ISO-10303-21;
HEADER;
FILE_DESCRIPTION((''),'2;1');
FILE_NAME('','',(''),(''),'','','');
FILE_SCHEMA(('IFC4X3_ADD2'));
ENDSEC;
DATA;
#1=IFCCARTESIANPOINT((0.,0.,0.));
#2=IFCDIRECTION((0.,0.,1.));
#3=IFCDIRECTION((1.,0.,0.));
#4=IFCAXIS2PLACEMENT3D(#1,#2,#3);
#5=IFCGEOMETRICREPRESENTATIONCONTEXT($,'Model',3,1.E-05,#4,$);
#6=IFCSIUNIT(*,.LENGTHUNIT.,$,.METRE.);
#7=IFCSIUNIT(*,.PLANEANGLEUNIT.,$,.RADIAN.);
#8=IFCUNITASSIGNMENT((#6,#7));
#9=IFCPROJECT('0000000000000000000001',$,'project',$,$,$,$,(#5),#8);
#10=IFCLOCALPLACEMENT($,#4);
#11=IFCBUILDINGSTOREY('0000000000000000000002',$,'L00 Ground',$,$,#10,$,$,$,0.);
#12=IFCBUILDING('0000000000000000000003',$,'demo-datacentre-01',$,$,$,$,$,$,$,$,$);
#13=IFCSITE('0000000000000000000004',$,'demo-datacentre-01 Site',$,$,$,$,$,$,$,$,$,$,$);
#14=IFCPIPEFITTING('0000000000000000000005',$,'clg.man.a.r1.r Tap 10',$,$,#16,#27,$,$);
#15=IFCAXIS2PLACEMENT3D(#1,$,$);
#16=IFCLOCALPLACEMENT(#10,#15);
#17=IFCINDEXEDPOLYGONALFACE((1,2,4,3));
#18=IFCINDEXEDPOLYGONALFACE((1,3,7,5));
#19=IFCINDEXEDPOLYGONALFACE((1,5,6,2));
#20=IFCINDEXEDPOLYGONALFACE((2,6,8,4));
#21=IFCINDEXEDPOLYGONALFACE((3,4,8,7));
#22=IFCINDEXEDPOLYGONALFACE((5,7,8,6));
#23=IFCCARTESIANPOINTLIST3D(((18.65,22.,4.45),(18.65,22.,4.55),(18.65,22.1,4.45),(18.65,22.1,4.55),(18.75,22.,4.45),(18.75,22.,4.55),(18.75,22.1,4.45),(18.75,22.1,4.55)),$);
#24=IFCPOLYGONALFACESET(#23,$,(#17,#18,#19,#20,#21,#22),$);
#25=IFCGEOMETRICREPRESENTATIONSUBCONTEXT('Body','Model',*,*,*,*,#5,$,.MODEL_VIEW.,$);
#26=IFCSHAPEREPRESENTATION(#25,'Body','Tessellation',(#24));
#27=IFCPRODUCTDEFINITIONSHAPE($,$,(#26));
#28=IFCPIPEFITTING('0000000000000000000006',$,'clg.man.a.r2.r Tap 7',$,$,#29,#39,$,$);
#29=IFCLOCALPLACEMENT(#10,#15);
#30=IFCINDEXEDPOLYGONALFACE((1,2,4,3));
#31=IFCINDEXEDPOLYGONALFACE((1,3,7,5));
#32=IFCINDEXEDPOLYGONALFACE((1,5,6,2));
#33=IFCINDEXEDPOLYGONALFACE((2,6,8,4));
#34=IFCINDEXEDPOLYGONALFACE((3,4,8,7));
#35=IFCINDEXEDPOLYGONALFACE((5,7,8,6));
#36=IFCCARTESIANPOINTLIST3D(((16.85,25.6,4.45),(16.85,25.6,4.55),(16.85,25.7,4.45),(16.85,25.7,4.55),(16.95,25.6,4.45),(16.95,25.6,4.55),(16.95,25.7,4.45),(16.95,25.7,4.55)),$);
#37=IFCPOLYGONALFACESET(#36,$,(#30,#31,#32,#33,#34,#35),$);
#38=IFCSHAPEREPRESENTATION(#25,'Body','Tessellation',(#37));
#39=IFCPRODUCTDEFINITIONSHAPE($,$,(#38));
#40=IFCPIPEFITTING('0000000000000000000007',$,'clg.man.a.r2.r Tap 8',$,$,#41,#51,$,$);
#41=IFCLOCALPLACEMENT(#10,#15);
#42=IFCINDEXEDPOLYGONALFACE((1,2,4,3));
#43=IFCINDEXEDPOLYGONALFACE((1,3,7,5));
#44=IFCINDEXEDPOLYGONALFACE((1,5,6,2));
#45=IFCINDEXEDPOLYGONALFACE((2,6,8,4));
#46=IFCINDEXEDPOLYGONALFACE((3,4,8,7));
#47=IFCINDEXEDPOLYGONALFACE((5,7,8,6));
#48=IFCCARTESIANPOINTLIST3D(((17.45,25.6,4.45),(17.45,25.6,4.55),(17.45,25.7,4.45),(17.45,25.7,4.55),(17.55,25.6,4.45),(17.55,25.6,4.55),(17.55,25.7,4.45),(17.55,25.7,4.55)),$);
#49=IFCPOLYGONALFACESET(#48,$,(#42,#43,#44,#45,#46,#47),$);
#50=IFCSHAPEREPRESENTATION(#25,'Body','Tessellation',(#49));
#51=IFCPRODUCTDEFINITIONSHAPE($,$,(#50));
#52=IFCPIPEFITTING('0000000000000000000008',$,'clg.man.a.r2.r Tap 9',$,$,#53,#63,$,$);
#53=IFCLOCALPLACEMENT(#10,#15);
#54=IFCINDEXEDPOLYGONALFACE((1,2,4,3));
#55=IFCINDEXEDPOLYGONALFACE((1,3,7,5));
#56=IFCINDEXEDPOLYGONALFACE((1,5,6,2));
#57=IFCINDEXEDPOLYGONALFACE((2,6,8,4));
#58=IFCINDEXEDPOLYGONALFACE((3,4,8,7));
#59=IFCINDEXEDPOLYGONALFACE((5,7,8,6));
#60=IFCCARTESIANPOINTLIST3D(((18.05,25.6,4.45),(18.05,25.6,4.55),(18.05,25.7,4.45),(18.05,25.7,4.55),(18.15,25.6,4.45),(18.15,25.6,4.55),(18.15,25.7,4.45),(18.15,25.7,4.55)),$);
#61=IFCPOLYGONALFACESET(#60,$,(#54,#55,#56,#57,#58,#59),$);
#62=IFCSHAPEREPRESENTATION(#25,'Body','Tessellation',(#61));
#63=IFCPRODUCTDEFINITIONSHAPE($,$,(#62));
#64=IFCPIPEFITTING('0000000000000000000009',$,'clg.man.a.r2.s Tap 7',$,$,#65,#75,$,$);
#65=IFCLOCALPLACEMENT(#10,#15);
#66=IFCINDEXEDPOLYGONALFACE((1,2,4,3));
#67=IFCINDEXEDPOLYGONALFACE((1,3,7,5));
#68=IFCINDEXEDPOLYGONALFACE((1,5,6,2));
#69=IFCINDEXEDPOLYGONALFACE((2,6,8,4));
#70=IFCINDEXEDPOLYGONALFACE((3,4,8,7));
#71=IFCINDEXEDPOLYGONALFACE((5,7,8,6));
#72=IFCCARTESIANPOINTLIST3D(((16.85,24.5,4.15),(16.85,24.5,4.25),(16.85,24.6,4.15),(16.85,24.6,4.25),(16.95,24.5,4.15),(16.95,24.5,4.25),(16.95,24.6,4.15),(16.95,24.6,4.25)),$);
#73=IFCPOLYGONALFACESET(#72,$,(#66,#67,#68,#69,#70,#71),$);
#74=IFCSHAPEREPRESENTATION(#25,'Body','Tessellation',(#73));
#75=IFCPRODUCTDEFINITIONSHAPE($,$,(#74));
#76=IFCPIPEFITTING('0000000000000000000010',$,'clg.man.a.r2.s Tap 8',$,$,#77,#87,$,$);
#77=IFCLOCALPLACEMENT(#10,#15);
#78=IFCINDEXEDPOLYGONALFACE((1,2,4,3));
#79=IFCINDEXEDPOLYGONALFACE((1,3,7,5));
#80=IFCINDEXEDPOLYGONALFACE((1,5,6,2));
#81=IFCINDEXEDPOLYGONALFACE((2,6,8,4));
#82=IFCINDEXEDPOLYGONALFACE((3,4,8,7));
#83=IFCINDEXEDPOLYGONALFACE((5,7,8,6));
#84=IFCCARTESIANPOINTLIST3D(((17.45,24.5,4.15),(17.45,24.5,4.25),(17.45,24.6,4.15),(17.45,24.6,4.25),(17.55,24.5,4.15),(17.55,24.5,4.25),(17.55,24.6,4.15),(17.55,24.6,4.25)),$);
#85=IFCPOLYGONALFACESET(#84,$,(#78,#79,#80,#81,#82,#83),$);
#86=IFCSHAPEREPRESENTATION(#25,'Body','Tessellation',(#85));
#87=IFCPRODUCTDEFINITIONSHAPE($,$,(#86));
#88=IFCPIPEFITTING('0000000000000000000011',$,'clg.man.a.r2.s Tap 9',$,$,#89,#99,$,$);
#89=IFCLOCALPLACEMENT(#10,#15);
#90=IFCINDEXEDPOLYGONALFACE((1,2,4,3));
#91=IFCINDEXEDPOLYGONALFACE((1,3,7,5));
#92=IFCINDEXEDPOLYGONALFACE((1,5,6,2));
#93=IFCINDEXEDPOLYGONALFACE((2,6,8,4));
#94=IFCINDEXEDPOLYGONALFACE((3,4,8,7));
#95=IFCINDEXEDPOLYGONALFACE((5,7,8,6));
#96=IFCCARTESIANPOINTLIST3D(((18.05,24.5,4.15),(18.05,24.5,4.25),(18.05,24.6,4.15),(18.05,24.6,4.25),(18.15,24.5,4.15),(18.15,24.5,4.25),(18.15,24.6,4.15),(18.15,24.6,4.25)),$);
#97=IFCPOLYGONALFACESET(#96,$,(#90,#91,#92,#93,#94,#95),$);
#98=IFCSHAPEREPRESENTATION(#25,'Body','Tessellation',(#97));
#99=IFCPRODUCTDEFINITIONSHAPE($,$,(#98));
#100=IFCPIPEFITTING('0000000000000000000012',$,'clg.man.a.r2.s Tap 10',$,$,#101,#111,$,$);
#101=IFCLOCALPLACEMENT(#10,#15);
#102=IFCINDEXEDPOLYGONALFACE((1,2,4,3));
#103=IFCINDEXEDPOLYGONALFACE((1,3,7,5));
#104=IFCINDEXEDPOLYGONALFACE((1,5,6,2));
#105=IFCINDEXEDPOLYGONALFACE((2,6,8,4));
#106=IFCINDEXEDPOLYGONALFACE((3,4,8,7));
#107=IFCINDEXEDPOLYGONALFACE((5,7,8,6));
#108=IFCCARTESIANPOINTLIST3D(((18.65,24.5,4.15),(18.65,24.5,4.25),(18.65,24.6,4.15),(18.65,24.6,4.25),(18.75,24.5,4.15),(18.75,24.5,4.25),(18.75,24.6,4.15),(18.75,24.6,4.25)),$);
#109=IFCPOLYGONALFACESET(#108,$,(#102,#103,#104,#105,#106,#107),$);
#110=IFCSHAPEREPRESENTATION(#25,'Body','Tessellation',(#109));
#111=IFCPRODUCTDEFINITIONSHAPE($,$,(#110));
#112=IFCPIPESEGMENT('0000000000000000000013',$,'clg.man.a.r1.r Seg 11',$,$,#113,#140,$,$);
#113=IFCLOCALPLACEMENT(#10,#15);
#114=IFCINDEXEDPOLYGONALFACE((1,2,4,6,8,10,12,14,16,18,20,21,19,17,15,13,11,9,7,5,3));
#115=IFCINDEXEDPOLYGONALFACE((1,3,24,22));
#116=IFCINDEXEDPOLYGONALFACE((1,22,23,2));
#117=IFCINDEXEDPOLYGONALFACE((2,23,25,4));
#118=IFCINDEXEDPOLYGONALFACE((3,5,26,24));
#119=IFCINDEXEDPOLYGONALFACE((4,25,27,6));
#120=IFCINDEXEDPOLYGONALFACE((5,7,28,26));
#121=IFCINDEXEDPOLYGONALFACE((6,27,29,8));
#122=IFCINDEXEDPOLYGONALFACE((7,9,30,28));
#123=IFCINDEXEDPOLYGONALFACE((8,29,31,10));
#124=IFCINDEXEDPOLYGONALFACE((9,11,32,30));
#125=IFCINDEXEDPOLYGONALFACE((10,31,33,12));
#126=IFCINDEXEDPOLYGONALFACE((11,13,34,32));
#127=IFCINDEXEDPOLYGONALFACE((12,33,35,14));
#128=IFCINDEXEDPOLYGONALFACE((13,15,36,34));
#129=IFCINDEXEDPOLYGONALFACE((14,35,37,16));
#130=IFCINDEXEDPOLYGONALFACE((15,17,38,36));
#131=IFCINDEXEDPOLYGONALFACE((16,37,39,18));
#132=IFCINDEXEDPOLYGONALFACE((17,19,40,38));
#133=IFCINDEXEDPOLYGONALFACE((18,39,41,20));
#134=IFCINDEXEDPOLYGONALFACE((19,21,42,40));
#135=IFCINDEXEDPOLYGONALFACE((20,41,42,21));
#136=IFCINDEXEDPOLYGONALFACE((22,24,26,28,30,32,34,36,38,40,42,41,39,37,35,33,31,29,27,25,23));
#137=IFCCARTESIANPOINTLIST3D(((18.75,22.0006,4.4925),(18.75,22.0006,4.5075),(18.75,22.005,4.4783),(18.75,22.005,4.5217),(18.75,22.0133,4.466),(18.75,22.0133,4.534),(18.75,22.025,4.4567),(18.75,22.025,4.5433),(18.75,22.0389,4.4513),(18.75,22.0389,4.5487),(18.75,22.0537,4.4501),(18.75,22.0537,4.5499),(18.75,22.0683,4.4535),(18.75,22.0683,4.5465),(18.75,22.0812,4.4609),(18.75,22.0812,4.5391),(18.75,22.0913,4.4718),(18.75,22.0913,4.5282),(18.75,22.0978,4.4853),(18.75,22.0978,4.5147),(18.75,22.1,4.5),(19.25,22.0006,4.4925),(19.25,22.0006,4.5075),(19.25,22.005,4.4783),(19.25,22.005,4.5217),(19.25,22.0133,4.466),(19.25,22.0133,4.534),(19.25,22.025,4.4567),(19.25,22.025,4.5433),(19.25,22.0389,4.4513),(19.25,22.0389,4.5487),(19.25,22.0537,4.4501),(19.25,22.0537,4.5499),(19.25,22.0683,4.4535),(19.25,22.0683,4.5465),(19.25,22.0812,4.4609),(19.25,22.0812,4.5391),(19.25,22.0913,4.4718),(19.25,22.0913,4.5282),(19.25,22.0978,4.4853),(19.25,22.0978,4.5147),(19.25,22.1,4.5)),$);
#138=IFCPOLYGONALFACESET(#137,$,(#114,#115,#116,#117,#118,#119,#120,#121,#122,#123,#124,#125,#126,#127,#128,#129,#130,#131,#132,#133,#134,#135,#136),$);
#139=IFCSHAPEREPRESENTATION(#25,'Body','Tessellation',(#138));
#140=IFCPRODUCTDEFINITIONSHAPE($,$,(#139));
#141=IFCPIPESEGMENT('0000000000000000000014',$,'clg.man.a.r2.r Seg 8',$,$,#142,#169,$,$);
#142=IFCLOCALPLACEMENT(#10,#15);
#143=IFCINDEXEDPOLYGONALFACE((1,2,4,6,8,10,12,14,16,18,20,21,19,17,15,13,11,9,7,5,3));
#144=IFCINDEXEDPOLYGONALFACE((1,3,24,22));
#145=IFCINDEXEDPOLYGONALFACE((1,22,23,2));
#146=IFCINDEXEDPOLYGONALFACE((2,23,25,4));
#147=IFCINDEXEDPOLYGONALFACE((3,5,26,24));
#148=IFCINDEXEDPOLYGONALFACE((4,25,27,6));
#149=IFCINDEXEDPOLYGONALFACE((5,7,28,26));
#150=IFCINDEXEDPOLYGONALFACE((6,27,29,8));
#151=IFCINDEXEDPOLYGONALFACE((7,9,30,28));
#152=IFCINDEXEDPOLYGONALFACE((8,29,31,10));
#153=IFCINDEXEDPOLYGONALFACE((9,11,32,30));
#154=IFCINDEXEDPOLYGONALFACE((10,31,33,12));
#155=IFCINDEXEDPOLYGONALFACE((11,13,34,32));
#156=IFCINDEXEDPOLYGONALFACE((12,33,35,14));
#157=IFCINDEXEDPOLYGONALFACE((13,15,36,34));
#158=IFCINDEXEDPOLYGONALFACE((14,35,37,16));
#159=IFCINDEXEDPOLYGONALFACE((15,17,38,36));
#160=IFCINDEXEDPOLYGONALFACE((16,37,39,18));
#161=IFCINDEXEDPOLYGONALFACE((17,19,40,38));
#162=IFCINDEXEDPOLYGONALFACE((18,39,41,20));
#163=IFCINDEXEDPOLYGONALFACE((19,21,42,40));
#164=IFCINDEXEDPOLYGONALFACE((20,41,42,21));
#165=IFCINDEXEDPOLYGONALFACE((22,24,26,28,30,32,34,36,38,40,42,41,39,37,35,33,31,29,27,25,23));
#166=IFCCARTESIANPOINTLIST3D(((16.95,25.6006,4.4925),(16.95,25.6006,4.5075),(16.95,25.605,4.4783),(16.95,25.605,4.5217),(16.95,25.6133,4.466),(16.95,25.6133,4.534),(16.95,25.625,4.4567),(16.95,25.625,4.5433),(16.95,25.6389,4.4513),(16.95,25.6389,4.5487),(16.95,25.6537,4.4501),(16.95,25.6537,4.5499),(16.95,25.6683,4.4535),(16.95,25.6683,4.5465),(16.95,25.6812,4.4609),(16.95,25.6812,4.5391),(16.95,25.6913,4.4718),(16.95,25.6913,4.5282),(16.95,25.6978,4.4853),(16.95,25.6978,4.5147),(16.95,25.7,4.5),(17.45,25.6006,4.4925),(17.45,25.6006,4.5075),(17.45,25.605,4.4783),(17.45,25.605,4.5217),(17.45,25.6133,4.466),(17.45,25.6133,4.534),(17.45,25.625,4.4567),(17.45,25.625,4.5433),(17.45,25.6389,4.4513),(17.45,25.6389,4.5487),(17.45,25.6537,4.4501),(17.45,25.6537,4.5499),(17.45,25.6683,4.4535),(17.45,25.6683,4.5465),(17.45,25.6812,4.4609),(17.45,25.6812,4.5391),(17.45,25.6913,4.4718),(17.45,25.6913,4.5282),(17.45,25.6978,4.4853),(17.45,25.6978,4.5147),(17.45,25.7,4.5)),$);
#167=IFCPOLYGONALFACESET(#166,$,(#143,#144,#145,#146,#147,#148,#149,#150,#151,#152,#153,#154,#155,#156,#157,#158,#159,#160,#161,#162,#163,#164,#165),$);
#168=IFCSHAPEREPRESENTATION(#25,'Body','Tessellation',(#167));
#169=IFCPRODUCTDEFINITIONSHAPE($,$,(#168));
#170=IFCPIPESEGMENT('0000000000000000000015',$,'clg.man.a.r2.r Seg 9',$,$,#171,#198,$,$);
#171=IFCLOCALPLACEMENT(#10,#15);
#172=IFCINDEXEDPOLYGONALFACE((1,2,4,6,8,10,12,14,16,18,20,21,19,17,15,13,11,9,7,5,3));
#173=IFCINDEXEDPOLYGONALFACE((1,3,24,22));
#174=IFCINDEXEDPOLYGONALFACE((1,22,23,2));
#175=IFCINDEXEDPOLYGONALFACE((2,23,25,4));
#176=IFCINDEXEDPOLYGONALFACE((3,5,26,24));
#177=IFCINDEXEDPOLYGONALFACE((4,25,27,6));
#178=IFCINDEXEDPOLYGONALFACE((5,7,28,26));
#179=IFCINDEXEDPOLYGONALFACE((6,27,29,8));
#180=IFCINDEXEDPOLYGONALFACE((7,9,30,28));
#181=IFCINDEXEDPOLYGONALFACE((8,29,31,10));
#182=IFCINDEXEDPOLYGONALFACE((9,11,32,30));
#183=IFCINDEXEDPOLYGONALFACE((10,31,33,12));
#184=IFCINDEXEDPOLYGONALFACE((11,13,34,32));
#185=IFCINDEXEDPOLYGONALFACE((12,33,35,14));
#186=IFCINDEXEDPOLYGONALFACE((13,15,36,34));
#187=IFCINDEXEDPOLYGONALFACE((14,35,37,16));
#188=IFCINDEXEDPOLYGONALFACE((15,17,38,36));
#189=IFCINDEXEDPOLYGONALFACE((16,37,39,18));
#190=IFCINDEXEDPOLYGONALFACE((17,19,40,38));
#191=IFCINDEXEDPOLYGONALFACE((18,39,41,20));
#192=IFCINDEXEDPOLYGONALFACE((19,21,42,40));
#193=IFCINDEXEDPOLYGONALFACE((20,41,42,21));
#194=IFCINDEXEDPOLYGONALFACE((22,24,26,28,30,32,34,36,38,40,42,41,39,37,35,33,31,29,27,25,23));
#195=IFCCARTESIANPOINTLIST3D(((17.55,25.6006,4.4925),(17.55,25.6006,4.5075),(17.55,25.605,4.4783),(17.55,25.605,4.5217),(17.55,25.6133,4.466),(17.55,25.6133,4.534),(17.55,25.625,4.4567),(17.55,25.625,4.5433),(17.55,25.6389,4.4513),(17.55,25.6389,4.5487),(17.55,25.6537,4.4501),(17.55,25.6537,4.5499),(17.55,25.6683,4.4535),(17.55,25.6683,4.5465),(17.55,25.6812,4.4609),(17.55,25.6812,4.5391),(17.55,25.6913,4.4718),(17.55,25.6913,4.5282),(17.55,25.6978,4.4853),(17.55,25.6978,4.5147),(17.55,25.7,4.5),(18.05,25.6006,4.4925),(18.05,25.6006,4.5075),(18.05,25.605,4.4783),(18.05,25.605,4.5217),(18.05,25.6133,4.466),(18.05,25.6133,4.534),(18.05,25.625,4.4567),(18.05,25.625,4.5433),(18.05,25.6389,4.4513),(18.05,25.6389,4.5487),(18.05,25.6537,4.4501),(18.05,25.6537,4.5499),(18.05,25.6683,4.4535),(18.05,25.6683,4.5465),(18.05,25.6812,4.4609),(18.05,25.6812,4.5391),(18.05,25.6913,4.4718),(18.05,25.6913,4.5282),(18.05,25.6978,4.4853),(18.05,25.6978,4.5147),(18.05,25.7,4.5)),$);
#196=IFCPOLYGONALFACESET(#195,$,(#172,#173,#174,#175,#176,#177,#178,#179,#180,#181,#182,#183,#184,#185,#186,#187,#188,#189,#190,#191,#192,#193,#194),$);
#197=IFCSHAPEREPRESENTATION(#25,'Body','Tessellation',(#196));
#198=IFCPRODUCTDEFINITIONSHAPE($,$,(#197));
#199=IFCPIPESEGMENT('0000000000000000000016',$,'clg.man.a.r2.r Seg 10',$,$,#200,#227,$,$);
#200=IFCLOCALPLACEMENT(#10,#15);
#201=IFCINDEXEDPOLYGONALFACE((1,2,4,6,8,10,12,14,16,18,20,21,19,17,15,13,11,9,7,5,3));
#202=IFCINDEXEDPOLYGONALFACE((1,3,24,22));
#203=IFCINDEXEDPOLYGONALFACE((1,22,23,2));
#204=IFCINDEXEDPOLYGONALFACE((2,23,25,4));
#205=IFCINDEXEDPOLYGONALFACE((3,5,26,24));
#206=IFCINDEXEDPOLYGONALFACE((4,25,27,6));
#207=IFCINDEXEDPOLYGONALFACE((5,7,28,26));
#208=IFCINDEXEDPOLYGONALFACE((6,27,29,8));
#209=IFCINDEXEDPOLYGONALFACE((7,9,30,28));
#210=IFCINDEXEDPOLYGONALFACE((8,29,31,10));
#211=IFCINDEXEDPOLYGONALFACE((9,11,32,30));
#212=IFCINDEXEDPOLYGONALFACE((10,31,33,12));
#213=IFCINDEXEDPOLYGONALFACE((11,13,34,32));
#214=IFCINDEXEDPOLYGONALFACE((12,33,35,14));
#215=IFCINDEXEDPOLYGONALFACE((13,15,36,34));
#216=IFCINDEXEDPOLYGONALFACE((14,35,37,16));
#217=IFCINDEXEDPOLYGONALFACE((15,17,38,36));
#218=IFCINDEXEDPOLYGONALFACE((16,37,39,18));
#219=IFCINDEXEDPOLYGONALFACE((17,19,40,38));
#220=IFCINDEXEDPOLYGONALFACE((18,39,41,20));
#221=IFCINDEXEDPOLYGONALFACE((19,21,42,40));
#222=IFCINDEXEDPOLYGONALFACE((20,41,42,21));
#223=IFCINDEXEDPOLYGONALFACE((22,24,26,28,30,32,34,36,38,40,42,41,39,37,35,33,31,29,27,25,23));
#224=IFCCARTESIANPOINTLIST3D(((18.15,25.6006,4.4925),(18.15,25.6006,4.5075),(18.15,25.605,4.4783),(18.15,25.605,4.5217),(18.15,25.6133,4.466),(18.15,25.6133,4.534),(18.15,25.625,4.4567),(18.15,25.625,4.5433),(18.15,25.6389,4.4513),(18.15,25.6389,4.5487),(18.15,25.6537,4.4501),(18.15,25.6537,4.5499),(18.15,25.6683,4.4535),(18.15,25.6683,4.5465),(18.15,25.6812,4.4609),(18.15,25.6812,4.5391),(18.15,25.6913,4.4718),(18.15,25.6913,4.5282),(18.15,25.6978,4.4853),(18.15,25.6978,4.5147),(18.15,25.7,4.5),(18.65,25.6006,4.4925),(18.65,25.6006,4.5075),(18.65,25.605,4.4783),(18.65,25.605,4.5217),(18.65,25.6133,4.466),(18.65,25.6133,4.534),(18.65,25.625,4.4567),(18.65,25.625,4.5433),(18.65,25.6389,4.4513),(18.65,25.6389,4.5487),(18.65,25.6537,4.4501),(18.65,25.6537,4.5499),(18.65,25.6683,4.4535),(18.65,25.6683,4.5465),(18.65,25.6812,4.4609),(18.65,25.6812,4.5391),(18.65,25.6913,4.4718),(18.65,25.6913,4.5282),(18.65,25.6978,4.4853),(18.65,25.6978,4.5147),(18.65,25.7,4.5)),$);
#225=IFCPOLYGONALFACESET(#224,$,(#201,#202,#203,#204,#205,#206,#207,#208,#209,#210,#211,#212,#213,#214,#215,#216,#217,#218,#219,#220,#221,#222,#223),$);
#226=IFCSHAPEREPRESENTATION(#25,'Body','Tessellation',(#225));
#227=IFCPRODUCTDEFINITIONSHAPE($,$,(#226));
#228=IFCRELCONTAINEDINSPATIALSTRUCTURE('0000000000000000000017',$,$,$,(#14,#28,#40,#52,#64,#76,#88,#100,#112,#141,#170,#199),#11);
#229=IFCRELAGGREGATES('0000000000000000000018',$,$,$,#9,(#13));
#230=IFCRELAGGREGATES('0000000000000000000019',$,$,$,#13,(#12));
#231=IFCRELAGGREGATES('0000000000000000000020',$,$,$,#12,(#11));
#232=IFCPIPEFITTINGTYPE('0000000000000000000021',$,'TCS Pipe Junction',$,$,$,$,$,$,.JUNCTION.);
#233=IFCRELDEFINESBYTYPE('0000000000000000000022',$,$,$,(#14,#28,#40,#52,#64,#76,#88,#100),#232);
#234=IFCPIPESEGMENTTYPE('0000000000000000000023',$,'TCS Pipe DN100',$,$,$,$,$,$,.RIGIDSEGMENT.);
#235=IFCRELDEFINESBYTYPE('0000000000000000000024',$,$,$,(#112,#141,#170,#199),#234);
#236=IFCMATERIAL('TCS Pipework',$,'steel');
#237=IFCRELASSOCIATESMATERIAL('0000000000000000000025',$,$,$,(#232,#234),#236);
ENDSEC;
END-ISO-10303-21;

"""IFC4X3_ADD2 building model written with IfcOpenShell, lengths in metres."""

from ifc_helpers import new_model, si_unit, frame, origin_with_axes, place, context, subcontext, project, spatial, rectangle, circle, extrude, material, type_object, element, save


model = new_model("IFC4X3_ADD2")

# Units and contexts
model_context = context("Model", 3, precision=1e-05, world=origin_with_axes())
body_context = subcontext(model_context, "Body", "Model", "MODEL_VIEW")
ifc_project = project(units=[si_unit("LENGTHUNIT", "METRE"), si_unit("PLANEANGLEUNIT", "RADIAN")], contexts=[model_context])

# Site, building, storey
site = spatial("IfcSite", under=ifc_project, Name="demo-datacentre-01 Site")
building = spatial("IfcBuilding", under=site, Name="demo-datacentre-01")
storey_placement = place(None, origin_with_axes())
storey = spatial("IfcBuildingStorey", under=building, at=storey_placement, Name="L00 Ground", Elevation=0.0)

# Pipe fittings
ifc_material = material(Name="TCS Pipework", Category="steel")
pipe_fitting_type = type_object("IfcPipeFittingType", Name="TCS Pipe Junction", PredefinedType="JUNCTION", material=ifc_material)
for number, where, z_axis, x_axis, name in (
    (1, (18.7, 22.05, 4.45), (0.0, 0.0, 1.0), (1.0, 0.0, 0.0), "clg.man.a.r1.r Tap 10"),
    (2, (16.9, 25.65, 4.45), (0.0, 0.0, 1.0), (1.0, 0.0, 0.0), "clg.man.a.r2.r Tap 7"),
    (3, (17.5, 25.65, 4.45), (0.0, 0.0, 1.0), (1.0, 0.0, 0.0), "clg.man.a.r2.r Tap 8"),
    (4, (18.1, 25.65, 4.45), (0.0, 0.0, 1.0), (1.0, 0.0, 0.0), "clg.man.a.r2.r Tap 9"),
    (5, (16.9, 24.55, 4.15), (0.0, 0.0, 1.0), (1.0, 0.0, 0.0), "clg.man.a.r2.s Tap 7"),
    (6, (17.5, 24.55, 4.15), (0.0, 0.0, 1.0), (1.0, 0.0, 0.0), "clg.man.a.r2.s Tap 8"),
    (7, (18.1, 24.55, 4.15), (0.0, 0.0, 1.0), (1.0, 0.0, 0.0), "clg.man.a.r2.s Tap 9"),
    (8, (18.7, 24.55, 4.15), (0.0, 0.0, 1.0), (1.0, 0.0, 0.0), "clg.man.a.r2.s Tap 10"),
):
    element("IfcPipeFitting", number, at=place(storey_placement, frame(where, z_axis=z_axis, x_axis=x_axis)), inside=storey, type_object=pipe_fitting_type, Name=name, context=body_context, shape_type="SweptSolid", body=[
        extrude(rectangle(XDim=0.1, YDim=0.1), origin_with_axes(), (0.0, 0.0, 1.0), 0.1),
    ])

# Pipe segments
pipe_segment_type_1 = type_object("IfcPipeSegmentType", Name="TCS Pipe DN100", PredefinedType="RIGIDSEGMENT", material=ifc_material)
for number, where, z_axis, x_axis, name in (
    (9, (18.75, 22.05, 4.5), (1.0, 0.0, 0.0), (0.0, 1.0, 0.0), "clg.man.a.r1.r Seg 11"),
    (10, (16.95, 25.65, 4.5), (1.0, 0.0, 0.0), (0.0, 1.0, 0.0), "clg.man.a.r2.r Seg 8"),
    (11, (17.55, 25.65, 4.5), (1.0, 0.0, 0.0), (0.0, 1.0, 0.0), "clg.man.a.r2.r Seg 9"),
):
    element("IfcPipeSegment", number, at=place(storey_placement, frame(where, z_axis=z_axis, x_axis=x_axis)), inside=storey, type_object=pipe_segment_type_1, Name=name, context=body_context, shape_type="SweptSolid", body=[
        extrude(circle(Radius=0.05), origin_with_axes(), (0.0, 0.0, 1.0), 0.5),
    ])
pipe_segment_1_placement = place(storey_placement, frame((18.15, 25.65, 4.5), z_axis=(1.0, 0.0, 0.0), x_axis=(0.0, 1.0, 0.0)))
element("IfcPipeSegment", 12, at=pipe_segment_1_placement, inside=storey, type_object=pipe_segment_type_1, Name="clg.man.a.r2.r Seg 10", context=body_context, shape_type="SweptSolid", body=[
    extrude(circle(Radius=0.05), origin_with_axes(), (0.0, 0.0, 1.0), 0.5),
])

save(model, "model.ifc")
